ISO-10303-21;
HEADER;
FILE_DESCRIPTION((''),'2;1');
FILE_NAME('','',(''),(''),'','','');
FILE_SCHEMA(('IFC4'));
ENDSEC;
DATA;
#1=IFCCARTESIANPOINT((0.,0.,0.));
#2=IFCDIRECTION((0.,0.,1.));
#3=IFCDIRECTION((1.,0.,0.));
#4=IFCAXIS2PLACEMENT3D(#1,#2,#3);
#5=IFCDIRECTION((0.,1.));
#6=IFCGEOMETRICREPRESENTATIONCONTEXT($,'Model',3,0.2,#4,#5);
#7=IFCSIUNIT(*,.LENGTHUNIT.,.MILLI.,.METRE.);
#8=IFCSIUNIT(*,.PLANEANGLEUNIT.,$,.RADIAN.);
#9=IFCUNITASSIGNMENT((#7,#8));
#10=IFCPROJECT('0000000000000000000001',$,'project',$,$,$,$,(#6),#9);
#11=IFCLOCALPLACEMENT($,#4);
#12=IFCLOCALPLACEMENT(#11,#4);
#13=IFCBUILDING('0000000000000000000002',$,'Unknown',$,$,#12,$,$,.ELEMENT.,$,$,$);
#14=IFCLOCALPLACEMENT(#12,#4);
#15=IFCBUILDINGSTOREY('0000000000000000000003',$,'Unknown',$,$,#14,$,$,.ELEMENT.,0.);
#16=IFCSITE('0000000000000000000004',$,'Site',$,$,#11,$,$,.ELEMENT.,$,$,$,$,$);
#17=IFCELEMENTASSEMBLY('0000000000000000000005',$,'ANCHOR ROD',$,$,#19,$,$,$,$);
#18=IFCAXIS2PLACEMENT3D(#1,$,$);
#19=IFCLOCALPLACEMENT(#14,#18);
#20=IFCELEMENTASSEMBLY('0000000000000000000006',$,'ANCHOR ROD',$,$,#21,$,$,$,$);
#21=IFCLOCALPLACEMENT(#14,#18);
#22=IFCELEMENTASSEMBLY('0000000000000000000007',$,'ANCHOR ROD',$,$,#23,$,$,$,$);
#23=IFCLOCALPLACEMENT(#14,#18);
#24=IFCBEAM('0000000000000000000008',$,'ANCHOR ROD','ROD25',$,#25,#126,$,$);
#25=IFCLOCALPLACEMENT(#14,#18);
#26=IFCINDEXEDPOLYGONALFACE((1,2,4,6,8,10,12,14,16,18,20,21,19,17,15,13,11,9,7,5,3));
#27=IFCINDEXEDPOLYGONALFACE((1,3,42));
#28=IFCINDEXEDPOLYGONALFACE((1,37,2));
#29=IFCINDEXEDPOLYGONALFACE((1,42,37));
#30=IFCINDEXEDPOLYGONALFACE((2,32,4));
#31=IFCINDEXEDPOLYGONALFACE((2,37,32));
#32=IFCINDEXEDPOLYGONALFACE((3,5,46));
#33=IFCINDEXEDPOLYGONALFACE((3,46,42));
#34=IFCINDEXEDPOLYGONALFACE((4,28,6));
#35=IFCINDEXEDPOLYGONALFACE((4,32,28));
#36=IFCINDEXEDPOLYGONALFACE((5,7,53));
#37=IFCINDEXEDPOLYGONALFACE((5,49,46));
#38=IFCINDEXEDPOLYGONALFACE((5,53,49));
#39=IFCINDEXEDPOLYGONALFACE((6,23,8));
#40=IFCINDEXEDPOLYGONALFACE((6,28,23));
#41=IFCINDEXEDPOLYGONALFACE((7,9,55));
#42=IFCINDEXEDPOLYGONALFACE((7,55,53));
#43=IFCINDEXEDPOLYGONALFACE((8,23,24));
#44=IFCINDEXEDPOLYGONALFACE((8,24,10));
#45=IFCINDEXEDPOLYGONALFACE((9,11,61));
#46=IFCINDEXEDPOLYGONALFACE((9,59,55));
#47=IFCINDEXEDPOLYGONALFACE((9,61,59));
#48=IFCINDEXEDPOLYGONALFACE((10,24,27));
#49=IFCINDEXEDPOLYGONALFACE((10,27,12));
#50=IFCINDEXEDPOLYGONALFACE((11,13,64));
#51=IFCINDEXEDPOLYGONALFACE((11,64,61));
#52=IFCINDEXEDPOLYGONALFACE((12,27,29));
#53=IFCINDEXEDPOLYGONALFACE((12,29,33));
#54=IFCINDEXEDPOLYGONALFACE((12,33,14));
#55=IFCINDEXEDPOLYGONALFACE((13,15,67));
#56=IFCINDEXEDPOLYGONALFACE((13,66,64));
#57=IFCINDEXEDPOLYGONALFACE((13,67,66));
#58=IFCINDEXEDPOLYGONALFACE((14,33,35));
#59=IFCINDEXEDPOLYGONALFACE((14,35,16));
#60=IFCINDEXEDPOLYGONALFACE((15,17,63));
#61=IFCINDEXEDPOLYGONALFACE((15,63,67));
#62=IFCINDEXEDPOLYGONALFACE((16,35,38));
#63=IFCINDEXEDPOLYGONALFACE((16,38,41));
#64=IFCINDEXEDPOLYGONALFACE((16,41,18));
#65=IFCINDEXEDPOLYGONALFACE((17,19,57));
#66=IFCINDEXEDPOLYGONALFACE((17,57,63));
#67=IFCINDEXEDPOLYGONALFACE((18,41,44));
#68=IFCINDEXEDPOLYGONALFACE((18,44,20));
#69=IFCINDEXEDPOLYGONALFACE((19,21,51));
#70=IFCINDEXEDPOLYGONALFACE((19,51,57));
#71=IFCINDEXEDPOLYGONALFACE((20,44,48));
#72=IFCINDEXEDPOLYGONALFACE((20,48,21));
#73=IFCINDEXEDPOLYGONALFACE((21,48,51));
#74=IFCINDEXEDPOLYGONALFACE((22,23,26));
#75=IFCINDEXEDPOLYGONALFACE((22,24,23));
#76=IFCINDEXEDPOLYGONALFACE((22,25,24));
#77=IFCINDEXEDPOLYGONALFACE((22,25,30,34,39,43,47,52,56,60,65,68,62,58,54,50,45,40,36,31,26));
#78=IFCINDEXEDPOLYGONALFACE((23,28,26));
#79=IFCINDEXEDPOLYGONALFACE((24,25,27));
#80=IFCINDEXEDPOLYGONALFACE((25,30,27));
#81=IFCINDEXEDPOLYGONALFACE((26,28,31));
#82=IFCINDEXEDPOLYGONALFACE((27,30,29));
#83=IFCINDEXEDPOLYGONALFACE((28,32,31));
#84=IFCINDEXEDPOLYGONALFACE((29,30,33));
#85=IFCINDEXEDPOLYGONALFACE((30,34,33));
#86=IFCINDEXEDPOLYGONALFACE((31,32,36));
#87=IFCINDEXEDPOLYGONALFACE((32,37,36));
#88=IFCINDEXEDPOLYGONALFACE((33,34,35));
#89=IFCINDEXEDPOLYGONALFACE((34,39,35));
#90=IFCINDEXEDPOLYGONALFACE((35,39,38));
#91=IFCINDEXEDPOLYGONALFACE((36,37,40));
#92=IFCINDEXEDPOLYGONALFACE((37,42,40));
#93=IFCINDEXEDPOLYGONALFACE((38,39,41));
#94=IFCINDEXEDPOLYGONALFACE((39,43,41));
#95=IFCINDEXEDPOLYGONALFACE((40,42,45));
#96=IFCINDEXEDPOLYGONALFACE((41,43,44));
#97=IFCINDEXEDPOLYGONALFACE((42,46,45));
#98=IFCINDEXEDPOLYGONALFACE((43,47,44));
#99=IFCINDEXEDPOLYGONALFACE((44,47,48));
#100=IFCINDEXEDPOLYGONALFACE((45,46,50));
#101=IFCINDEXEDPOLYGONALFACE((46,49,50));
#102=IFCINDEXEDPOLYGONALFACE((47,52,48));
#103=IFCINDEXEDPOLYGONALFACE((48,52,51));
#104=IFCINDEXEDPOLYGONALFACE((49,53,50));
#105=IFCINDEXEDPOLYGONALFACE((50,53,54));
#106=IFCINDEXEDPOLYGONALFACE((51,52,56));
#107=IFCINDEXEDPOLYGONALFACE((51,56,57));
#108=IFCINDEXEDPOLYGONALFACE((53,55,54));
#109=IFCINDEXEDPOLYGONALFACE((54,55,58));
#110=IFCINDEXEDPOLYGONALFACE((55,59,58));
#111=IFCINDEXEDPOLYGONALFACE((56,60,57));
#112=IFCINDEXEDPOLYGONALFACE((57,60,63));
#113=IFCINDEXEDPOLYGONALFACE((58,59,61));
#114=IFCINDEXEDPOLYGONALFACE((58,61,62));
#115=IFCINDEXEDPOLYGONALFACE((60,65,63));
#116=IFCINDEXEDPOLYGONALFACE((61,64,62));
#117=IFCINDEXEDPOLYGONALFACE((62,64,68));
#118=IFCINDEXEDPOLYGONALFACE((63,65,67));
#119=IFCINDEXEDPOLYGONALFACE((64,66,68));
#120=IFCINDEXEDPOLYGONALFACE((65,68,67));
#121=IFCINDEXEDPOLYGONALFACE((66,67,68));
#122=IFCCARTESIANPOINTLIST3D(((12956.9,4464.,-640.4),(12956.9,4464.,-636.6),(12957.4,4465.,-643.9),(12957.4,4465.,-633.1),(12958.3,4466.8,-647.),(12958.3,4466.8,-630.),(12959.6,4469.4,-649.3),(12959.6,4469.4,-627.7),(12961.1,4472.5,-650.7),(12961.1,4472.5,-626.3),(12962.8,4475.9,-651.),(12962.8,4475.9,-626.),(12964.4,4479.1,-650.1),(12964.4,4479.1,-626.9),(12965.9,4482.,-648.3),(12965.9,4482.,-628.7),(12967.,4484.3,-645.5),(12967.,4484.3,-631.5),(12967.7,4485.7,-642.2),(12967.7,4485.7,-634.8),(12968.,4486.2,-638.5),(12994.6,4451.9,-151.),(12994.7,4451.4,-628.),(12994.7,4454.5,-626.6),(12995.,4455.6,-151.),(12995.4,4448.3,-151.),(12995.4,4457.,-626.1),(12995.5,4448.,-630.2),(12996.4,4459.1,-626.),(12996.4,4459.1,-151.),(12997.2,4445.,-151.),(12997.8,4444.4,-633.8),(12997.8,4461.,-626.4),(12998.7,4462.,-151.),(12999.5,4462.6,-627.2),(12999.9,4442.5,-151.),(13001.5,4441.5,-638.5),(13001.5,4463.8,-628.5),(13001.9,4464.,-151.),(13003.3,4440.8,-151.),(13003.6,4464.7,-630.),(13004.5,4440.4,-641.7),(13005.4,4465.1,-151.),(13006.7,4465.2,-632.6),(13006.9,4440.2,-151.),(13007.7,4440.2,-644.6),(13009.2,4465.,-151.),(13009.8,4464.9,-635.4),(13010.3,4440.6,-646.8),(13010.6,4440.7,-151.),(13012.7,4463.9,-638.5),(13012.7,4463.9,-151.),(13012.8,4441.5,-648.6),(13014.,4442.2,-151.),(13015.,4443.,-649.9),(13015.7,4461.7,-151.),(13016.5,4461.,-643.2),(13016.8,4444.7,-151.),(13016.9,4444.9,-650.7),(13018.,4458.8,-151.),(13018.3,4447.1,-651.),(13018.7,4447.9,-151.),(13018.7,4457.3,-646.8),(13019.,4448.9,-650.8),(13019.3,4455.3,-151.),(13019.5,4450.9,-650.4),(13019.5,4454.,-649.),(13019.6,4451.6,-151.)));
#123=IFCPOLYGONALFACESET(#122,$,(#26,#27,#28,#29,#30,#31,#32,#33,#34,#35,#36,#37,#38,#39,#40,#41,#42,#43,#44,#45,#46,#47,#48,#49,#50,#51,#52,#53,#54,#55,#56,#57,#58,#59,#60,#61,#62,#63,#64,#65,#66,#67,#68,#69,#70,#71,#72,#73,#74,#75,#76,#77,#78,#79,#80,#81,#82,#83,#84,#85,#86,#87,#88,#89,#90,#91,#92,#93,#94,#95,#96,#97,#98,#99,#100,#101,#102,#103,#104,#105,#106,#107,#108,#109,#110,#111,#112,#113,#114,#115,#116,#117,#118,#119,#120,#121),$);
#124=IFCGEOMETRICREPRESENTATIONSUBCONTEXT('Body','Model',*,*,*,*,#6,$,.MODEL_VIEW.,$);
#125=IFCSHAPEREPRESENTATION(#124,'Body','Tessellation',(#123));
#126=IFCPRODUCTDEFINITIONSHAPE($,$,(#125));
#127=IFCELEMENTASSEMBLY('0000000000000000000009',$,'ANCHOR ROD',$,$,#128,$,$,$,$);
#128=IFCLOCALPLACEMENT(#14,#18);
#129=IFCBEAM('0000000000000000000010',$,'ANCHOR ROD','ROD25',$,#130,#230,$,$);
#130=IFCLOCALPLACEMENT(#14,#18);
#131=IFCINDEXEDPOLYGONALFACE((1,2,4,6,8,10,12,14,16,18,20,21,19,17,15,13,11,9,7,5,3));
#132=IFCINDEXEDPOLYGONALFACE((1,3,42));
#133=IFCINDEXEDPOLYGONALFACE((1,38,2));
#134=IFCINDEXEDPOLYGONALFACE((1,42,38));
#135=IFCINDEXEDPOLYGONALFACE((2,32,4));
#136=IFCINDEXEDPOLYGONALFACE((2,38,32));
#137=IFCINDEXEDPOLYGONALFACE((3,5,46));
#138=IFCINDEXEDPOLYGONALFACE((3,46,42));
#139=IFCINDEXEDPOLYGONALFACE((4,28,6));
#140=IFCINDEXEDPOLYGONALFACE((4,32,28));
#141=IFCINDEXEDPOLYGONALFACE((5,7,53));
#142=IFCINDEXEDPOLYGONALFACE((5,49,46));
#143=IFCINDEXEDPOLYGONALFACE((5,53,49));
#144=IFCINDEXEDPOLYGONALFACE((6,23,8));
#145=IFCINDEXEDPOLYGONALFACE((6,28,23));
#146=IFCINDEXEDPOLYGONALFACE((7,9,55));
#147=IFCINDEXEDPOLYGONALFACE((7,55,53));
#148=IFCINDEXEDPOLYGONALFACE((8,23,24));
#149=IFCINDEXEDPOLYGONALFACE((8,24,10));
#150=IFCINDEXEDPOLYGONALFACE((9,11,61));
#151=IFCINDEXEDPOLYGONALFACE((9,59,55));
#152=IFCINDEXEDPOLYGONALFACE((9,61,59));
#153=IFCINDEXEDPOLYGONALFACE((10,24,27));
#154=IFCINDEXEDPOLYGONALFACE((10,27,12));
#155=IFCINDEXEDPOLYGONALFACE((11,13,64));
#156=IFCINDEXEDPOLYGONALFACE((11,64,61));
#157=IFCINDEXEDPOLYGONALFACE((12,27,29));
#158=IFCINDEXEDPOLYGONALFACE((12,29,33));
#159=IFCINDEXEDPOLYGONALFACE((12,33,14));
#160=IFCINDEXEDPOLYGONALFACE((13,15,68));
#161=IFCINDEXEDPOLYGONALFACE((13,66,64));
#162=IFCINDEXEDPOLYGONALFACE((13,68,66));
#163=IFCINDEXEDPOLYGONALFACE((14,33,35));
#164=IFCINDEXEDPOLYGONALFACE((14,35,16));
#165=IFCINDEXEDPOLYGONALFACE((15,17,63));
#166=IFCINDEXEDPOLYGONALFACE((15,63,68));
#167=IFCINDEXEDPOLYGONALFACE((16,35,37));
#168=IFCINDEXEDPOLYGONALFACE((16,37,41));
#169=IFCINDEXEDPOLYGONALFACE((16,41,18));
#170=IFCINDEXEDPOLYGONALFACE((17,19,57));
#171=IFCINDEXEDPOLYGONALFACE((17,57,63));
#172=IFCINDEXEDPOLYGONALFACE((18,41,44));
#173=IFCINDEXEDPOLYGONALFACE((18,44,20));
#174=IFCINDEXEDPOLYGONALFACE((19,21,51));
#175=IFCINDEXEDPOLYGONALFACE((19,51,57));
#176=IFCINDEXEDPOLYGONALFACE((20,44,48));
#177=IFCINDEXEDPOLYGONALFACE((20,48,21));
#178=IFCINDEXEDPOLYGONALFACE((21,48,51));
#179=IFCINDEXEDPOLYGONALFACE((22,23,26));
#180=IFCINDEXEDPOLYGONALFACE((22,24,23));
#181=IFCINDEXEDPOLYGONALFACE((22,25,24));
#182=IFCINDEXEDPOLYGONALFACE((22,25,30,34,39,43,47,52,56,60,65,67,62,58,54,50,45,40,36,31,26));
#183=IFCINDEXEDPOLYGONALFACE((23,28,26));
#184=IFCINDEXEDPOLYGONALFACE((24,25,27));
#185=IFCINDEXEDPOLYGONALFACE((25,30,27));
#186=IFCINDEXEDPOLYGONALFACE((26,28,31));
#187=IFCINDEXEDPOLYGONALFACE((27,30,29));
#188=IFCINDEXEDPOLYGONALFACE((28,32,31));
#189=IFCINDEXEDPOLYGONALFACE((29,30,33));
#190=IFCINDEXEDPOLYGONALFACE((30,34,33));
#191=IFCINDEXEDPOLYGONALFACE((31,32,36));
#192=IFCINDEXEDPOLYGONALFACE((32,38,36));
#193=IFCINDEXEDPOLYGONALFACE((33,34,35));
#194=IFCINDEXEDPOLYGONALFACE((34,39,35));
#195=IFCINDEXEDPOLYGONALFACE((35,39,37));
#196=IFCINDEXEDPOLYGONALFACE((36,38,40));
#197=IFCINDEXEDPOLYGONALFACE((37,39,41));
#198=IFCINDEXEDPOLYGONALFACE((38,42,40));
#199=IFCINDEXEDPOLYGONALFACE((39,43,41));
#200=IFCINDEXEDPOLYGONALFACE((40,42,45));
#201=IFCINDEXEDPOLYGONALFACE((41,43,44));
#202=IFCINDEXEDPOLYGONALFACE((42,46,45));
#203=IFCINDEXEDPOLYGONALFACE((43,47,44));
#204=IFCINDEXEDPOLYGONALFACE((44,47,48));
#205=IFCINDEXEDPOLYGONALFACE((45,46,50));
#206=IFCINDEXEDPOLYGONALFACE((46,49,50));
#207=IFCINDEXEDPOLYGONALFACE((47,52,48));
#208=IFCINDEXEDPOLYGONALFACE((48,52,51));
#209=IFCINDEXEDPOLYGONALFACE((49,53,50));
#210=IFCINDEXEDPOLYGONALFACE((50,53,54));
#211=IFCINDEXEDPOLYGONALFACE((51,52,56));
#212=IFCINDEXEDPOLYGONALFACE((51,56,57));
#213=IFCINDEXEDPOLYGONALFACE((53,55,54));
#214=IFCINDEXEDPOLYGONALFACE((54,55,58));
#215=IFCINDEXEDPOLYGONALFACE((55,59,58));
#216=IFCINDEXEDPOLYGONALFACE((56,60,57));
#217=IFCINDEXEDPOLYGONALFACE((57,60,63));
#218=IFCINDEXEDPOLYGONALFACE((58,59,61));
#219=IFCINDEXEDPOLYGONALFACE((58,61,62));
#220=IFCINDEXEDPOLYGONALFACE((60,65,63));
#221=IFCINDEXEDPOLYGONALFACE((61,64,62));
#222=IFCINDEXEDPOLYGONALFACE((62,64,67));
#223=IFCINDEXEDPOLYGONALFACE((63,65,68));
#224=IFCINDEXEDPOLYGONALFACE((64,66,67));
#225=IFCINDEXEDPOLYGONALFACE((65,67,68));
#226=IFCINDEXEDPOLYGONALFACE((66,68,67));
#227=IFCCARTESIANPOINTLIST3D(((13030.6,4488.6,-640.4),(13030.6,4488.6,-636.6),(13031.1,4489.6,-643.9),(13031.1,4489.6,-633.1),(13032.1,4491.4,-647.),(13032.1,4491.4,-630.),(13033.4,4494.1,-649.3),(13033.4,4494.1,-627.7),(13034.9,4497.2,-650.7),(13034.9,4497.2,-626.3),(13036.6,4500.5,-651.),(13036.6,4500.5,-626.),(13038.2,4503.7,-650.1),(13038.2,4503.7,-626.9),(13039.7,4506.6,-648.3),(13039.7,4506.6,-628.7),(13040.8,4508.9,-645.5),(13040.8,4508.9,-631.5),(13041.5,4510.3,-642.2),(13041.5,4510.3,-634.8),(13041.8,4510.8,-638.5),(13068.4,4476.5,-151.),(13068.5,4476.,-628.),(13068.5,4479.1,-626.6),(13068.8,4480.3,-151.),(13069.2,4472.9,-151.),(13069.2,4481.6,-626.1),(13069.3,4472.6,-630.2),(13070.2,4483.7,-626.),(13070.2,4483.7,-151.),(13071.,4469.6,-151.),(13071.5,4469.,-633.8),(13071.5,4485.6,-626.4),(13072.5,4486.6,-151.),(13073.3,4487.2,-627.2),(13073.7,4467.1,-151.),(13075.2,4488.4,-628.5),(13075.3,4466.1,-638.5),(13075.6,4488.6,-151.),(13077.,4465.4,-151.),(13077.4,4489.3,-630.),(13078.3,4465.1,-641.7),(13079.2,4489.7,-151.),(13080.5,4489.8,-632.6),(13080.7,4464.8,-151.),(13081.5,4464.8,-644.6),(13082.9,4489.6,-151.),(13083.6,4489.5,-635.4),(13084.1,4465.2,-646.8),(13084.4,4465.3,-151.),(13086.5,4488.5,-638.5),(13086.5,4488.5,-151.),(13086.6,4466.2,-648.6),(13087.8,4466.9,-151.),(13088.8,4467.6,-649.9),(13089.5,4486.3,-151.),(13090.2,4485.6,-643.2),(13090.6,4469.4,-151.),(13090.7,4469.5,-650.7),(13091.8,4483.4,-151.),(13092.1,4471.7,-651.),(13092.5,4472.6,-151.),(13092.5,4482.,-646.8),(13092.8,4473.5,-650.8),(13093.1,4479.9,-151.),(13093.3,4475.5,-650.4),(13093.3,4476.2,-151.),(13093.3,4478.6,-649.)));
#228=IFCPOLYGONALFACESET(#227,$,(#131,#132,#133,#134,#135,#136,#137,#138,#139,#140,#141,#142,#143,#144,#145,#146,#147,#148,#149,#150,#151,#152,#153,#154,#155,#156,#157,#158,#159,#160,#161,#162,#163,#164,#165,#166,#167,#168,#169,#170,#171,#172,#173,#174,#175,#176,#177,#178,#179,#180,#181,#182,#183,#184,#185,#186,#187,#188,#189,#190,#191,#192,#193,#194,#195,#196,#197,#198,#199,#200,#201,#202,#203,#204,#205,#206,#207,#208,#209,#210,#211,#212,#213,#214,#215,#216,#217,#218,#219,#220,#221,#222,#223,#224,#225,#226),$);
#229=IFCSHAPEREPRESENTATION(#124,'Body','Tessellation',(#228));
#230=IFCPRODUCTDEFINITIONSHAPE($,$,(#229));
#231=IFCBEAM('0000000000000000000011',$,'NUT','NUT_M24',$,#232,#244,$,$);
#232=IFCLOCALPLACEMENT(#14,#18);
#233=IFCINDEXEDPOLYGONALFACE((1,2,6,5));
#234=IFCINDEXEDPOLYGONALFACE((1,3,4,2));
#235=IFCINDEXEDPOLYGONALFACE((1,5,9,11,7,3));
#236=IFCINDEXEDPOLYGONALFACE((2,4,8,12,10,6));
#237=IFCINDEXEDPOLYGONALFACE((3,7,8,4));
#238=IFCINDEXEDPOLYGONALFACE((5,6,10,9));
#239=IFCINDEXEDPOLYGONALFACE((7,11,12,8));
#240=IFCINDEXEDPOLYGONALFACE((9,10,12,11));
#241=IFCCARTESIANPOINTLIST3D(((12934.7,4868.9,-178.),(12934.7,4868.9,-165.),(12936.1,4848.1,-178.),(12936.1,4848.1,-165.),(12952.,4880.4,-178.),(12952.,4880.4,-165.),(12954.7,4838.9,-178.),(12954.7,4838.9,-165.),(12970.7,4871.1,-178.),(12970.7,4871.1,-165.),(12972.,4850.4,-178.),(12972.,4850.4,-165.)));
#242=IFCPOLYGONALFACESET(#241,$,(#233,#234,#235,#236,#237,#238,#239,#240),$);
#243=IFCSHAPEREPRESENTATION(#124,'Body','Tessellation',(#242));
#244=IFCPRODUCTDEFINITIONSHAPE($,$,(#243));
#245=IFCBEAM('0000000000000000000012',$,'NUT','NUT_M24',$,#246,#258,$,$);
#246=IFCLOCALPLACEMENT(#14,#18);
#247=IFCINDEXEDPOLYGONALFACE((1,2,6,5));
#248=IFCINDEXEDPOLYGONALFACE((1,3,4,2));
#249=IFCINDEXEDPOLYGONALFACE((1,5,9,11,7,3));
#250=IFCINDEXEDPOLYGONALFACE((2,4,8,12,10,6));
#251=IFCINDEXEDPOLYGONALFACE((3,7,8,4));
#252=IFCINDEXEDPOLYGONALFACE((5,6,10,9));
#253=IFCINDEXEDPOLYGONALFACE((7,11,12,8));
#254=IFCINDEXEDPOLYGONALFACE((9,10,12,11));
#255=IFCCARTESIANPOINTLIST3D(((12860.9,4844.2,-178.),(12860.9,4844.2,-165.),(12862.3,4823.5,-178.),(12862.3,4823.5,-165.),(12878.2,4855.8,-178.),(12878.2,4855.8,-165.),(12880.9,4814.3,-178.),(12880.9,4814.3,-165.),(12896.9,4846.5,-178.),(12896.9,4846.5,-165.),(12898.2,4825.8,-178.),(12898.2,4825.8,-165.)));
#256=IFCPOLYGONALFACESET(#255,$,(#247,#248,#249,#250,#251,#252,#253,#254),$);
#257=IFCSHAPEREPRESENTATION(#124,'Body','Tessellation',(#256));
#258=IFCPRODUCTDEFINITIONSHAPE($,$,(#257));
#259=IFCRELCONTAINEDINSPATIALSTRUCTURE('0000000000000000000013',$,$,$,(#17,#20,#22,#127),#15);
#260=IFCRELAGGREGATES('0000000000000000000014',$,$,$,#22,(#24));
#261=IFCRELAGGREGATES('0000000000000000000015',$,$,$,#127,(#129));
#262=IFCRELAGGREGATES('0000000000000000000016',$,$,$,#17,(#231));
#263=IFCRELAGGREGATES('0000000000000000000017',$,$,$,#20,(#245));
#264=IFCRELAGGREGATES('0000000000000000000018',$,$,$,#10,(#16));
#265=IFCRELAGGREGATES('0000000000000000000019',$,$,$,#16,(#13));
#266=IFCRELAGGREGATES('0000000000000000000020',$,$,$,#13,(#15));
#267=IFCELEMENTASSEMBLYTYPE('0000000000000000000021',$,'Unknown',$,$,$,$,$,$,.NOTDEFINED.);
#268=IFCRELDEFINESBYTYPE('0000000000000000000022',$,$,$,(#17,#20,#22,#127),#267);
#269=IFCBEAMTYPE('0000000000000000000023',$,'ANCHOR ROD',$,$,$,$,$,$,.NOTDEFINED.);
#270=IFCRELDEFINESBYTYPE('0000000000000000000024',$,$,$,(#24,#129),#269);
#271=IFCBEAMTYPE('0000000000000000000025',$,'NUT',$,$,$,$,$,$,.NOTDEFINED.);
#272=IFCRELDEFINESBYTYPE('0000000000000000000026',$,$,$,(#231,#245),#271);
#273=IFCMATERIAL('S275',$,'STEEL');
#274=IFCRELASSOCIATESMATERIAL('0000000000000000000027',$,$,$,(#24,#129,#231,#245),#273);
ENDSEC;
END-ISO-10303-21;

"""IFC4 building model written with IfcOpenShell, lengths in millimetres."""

from ifc_helpers import new_model, entity, si_unit, direction, frame, origin_with_axes, place, context, subcontext, project, spatial, polyline, outline, extrude, material, material_profile, profile_set, profile_usage, type_object, element, aggregate, save


model = new_model("IFC4")

# Units and contexts
model_context = context("Model", 3, precision=0.2, world=origin_with_axes(), true_north=direction((0.0, 1.0)))
body_context = subcontext(model_context, "Body", "Model", "MODEL_VIEW")
ifc_project = project(units=[si_unit("LENGTHUNIT", "METRE", prefix="MILLI"), si_unit("PLANEANGLEUNIT", "RADIAN")], contexts=[model_context])

# Site, building, storey
site_placement = place(None, origin_with_axes())
site = spatial("IfcSite", under=ifc_project, at=site_placement, Name="Site", CompositionType="ELEMENT")
building_placement = place(site_placement, origin_with_axes())
building = spatial("IfcBuilding", under=site, at=building_placement, Name="Unknown", CompositionType="ELEMENT")
storey_placement = place(building_placement, origin_with_axes())
storey = spatial("IfcBuildingStorey", under=building, at=storey_placement, Name="Unknown", CompositionType="ELEMENT", Elevation=0.0)

# Element assemblies, beams
element_assembly_type = type_object("IfcElementAssemblyType", Name="Unknown", PredefinedType="NOTDEFINED")
assembly_1_placement = place(storey_placement, frame((12953.4, 4859.6, -151.0), z_axis=(-0.447009, -0.89453, 0.0), x_axis=(0.0, 0.0, -1.0)))
assembly_1 = element("IfcElementAssembly", 1, at=assembly_1_placement, inside=storey, type_object=element_assembly_type, Name="ANCHOR ROD")
ifc_material_1 = material(Name="S275", Category="STEEL")
beam_type_1 = type_object("IfcBeamType", Name="ANCHOR ROD", PredefinedType="NOTDEFINED")
assembly_2_placement = place(storey_placement, frame((12879.6, 4835.0, -151.0), z_axis=(-0.447009, -0.89453, 0.0), x_axis=(0.0, 0.0, -1.0)))
assembly_2 = element("IfcElementAssembly", 2, at=assembly_2_placement, inside=storey, type_object=element_assembly_type, Name="ANCHOR ROD")
assembly_3_placement = place(storey_placement, frame((13007.1, 4452.7, -151.0), z_axis=(0.447009, 0.89453, 0.0), x_axis=(0.0, 0.0, -1.0)))
assembly_3 = element("IfcElementAssembly", 3, at=assembly_3_placement, inside=storey, type_object=element_assembly_type, Name="ANCHOR ROD")
beam_1_placement = place(assembly_3_placement, origin_with_axes())
beam_1 = element("IfcBeam", 4, at=beam_1_placement, type_object=beam_type_1, material=ifc_material_1, Name="ANCHOR ROD", Description="ROD25", context=body_context, shape_type="SolidModel", body=[
    entity("IfcSweptDiskSolid", entity("IfcIndexedPolyCurve", entity("IfcCartesianPointList3D", [[0.0, 0.0, 0.0], [487.5, 0.0, 0.0], [487.5, 50.0, 0.0]]), [entity("IfcLineIndex", [1, 2, 3])]), 12.5),
])
aggregate(assembly_3, [beam_1])
assembly_4_placement = place(storey_placement, frame((13080.9, 4477.3, -151.0), z_axis=(0.447009, 0.89453, 0.0), x_axis=(0.0, 0.0, -1.0)))
assembly_4 = element("IfcElementAssembly", 5, at=assembly_4_placement, inside=storey, type_object=element_assembly_type, Name="ANCHOR ROD")
beam_2_placement = place(assembly_4_placement, origin_with_axes())
beam_2 = element("IfcBeam", 6, at=beam_2_placement, type_object=beam_type_1, material=ifc_material_1, Name="ANCHOR ROD", Description="ROD25", context=body_context, shape_type="SolidModel", body=[
    entity("IfcSweptDiskSolid", entity("IfcIndexedPolyCurve", entity("IfcCartesianPointList3D", [[0.0, 0.0, 0.0], [487.5, 0.0, 0.0], [487.5, 50.0, 0.0]]), [entity("IfcLineIndex", [1, 2, 3])]), 12.5),
])
aggregate(assembly_4, [beam_2])

# Beams
ifc_material_profile_1 = material_profile(ifc_material_1, outline(polyline([(18.0, 10.4), (0.0, 20.8), (-18.0, 10.4), (-18.0, -10.4), (0.0, -20.8), (18.0, -10.4), (18.0, 10.4)])), Name="NUT_M24")
ifc_profile_set_1 = profile_set([ifc_material_profile_1])
ifc_profile_usage_1 = profile_usage(ifc_profile_set_1, cardinal=5)
beam_type_2 = type_object("IfcBeamType", Name="NUT", PredefinedType="NOTDEFINED")
beam_3_placement = place(assembly_1_placement, frame((14.0, 0.0, 0.0), z_axis=(0.0, -0.003456, -0.999994), x_axis=(1.0, 0.0, 0.0)))
beam_3 = element("IfcBeam", 7, at=beam_3_placement, type_object=beam_type_2, material=ifc_profile_usage_1, Name="NUT", Description="NUT_M24", context=body_context, shape_type="SolidModel", body=[
    extrude(outline(polyline([(18.0, 10.4), (0.0, 20.8), (-18.0, 10.4), (-18.0, -10.4), (0.0, -20.8), (18.0, -10.4), (18.0, 10.4)])), frame((0.0, 0.0, 0.0), z_axis=(-1.0, 0.0, 0.0), x_axis=(0.0, 0.0, 1.0)), (0.0, 0.0, -1.0), 13.0),
])
aggregate(assembly_1, [beam_3])
beam_4_placement = place(assembly_2_placement, frame((14.0, 0.0, 0.0), z_axis=(0.0, -0.003456, -0.999994), x_axis=(1.0, 0.0, 0.0)))
beam_4 = element("IfcBeam", 8, at=beam_4_placement, type_object=beam_type_2, material=ifc_profile_usage_1, Name="NUT", Description="NUT_M24", context=body_context, shape_type="SolidModel", body=[
    extrude(outline(polyline([(18.0, 10.4), (0.0, 20.8), (-18.0, 10.4), (-18.0, -10.4), (0.0, -20.8), (18.0, -10.4), (18.0, 10.4)])), frame((0.0, 0.0, 0.0), z_axis=(-1.0, 0.0, 0.0), x_axis=(0.0, 0.0, 1.0)), (0.0, 0.0, -1.0), 13.0),
])
aggregate(assembly_2, [beam_4])

save(model, "model.ifc")
